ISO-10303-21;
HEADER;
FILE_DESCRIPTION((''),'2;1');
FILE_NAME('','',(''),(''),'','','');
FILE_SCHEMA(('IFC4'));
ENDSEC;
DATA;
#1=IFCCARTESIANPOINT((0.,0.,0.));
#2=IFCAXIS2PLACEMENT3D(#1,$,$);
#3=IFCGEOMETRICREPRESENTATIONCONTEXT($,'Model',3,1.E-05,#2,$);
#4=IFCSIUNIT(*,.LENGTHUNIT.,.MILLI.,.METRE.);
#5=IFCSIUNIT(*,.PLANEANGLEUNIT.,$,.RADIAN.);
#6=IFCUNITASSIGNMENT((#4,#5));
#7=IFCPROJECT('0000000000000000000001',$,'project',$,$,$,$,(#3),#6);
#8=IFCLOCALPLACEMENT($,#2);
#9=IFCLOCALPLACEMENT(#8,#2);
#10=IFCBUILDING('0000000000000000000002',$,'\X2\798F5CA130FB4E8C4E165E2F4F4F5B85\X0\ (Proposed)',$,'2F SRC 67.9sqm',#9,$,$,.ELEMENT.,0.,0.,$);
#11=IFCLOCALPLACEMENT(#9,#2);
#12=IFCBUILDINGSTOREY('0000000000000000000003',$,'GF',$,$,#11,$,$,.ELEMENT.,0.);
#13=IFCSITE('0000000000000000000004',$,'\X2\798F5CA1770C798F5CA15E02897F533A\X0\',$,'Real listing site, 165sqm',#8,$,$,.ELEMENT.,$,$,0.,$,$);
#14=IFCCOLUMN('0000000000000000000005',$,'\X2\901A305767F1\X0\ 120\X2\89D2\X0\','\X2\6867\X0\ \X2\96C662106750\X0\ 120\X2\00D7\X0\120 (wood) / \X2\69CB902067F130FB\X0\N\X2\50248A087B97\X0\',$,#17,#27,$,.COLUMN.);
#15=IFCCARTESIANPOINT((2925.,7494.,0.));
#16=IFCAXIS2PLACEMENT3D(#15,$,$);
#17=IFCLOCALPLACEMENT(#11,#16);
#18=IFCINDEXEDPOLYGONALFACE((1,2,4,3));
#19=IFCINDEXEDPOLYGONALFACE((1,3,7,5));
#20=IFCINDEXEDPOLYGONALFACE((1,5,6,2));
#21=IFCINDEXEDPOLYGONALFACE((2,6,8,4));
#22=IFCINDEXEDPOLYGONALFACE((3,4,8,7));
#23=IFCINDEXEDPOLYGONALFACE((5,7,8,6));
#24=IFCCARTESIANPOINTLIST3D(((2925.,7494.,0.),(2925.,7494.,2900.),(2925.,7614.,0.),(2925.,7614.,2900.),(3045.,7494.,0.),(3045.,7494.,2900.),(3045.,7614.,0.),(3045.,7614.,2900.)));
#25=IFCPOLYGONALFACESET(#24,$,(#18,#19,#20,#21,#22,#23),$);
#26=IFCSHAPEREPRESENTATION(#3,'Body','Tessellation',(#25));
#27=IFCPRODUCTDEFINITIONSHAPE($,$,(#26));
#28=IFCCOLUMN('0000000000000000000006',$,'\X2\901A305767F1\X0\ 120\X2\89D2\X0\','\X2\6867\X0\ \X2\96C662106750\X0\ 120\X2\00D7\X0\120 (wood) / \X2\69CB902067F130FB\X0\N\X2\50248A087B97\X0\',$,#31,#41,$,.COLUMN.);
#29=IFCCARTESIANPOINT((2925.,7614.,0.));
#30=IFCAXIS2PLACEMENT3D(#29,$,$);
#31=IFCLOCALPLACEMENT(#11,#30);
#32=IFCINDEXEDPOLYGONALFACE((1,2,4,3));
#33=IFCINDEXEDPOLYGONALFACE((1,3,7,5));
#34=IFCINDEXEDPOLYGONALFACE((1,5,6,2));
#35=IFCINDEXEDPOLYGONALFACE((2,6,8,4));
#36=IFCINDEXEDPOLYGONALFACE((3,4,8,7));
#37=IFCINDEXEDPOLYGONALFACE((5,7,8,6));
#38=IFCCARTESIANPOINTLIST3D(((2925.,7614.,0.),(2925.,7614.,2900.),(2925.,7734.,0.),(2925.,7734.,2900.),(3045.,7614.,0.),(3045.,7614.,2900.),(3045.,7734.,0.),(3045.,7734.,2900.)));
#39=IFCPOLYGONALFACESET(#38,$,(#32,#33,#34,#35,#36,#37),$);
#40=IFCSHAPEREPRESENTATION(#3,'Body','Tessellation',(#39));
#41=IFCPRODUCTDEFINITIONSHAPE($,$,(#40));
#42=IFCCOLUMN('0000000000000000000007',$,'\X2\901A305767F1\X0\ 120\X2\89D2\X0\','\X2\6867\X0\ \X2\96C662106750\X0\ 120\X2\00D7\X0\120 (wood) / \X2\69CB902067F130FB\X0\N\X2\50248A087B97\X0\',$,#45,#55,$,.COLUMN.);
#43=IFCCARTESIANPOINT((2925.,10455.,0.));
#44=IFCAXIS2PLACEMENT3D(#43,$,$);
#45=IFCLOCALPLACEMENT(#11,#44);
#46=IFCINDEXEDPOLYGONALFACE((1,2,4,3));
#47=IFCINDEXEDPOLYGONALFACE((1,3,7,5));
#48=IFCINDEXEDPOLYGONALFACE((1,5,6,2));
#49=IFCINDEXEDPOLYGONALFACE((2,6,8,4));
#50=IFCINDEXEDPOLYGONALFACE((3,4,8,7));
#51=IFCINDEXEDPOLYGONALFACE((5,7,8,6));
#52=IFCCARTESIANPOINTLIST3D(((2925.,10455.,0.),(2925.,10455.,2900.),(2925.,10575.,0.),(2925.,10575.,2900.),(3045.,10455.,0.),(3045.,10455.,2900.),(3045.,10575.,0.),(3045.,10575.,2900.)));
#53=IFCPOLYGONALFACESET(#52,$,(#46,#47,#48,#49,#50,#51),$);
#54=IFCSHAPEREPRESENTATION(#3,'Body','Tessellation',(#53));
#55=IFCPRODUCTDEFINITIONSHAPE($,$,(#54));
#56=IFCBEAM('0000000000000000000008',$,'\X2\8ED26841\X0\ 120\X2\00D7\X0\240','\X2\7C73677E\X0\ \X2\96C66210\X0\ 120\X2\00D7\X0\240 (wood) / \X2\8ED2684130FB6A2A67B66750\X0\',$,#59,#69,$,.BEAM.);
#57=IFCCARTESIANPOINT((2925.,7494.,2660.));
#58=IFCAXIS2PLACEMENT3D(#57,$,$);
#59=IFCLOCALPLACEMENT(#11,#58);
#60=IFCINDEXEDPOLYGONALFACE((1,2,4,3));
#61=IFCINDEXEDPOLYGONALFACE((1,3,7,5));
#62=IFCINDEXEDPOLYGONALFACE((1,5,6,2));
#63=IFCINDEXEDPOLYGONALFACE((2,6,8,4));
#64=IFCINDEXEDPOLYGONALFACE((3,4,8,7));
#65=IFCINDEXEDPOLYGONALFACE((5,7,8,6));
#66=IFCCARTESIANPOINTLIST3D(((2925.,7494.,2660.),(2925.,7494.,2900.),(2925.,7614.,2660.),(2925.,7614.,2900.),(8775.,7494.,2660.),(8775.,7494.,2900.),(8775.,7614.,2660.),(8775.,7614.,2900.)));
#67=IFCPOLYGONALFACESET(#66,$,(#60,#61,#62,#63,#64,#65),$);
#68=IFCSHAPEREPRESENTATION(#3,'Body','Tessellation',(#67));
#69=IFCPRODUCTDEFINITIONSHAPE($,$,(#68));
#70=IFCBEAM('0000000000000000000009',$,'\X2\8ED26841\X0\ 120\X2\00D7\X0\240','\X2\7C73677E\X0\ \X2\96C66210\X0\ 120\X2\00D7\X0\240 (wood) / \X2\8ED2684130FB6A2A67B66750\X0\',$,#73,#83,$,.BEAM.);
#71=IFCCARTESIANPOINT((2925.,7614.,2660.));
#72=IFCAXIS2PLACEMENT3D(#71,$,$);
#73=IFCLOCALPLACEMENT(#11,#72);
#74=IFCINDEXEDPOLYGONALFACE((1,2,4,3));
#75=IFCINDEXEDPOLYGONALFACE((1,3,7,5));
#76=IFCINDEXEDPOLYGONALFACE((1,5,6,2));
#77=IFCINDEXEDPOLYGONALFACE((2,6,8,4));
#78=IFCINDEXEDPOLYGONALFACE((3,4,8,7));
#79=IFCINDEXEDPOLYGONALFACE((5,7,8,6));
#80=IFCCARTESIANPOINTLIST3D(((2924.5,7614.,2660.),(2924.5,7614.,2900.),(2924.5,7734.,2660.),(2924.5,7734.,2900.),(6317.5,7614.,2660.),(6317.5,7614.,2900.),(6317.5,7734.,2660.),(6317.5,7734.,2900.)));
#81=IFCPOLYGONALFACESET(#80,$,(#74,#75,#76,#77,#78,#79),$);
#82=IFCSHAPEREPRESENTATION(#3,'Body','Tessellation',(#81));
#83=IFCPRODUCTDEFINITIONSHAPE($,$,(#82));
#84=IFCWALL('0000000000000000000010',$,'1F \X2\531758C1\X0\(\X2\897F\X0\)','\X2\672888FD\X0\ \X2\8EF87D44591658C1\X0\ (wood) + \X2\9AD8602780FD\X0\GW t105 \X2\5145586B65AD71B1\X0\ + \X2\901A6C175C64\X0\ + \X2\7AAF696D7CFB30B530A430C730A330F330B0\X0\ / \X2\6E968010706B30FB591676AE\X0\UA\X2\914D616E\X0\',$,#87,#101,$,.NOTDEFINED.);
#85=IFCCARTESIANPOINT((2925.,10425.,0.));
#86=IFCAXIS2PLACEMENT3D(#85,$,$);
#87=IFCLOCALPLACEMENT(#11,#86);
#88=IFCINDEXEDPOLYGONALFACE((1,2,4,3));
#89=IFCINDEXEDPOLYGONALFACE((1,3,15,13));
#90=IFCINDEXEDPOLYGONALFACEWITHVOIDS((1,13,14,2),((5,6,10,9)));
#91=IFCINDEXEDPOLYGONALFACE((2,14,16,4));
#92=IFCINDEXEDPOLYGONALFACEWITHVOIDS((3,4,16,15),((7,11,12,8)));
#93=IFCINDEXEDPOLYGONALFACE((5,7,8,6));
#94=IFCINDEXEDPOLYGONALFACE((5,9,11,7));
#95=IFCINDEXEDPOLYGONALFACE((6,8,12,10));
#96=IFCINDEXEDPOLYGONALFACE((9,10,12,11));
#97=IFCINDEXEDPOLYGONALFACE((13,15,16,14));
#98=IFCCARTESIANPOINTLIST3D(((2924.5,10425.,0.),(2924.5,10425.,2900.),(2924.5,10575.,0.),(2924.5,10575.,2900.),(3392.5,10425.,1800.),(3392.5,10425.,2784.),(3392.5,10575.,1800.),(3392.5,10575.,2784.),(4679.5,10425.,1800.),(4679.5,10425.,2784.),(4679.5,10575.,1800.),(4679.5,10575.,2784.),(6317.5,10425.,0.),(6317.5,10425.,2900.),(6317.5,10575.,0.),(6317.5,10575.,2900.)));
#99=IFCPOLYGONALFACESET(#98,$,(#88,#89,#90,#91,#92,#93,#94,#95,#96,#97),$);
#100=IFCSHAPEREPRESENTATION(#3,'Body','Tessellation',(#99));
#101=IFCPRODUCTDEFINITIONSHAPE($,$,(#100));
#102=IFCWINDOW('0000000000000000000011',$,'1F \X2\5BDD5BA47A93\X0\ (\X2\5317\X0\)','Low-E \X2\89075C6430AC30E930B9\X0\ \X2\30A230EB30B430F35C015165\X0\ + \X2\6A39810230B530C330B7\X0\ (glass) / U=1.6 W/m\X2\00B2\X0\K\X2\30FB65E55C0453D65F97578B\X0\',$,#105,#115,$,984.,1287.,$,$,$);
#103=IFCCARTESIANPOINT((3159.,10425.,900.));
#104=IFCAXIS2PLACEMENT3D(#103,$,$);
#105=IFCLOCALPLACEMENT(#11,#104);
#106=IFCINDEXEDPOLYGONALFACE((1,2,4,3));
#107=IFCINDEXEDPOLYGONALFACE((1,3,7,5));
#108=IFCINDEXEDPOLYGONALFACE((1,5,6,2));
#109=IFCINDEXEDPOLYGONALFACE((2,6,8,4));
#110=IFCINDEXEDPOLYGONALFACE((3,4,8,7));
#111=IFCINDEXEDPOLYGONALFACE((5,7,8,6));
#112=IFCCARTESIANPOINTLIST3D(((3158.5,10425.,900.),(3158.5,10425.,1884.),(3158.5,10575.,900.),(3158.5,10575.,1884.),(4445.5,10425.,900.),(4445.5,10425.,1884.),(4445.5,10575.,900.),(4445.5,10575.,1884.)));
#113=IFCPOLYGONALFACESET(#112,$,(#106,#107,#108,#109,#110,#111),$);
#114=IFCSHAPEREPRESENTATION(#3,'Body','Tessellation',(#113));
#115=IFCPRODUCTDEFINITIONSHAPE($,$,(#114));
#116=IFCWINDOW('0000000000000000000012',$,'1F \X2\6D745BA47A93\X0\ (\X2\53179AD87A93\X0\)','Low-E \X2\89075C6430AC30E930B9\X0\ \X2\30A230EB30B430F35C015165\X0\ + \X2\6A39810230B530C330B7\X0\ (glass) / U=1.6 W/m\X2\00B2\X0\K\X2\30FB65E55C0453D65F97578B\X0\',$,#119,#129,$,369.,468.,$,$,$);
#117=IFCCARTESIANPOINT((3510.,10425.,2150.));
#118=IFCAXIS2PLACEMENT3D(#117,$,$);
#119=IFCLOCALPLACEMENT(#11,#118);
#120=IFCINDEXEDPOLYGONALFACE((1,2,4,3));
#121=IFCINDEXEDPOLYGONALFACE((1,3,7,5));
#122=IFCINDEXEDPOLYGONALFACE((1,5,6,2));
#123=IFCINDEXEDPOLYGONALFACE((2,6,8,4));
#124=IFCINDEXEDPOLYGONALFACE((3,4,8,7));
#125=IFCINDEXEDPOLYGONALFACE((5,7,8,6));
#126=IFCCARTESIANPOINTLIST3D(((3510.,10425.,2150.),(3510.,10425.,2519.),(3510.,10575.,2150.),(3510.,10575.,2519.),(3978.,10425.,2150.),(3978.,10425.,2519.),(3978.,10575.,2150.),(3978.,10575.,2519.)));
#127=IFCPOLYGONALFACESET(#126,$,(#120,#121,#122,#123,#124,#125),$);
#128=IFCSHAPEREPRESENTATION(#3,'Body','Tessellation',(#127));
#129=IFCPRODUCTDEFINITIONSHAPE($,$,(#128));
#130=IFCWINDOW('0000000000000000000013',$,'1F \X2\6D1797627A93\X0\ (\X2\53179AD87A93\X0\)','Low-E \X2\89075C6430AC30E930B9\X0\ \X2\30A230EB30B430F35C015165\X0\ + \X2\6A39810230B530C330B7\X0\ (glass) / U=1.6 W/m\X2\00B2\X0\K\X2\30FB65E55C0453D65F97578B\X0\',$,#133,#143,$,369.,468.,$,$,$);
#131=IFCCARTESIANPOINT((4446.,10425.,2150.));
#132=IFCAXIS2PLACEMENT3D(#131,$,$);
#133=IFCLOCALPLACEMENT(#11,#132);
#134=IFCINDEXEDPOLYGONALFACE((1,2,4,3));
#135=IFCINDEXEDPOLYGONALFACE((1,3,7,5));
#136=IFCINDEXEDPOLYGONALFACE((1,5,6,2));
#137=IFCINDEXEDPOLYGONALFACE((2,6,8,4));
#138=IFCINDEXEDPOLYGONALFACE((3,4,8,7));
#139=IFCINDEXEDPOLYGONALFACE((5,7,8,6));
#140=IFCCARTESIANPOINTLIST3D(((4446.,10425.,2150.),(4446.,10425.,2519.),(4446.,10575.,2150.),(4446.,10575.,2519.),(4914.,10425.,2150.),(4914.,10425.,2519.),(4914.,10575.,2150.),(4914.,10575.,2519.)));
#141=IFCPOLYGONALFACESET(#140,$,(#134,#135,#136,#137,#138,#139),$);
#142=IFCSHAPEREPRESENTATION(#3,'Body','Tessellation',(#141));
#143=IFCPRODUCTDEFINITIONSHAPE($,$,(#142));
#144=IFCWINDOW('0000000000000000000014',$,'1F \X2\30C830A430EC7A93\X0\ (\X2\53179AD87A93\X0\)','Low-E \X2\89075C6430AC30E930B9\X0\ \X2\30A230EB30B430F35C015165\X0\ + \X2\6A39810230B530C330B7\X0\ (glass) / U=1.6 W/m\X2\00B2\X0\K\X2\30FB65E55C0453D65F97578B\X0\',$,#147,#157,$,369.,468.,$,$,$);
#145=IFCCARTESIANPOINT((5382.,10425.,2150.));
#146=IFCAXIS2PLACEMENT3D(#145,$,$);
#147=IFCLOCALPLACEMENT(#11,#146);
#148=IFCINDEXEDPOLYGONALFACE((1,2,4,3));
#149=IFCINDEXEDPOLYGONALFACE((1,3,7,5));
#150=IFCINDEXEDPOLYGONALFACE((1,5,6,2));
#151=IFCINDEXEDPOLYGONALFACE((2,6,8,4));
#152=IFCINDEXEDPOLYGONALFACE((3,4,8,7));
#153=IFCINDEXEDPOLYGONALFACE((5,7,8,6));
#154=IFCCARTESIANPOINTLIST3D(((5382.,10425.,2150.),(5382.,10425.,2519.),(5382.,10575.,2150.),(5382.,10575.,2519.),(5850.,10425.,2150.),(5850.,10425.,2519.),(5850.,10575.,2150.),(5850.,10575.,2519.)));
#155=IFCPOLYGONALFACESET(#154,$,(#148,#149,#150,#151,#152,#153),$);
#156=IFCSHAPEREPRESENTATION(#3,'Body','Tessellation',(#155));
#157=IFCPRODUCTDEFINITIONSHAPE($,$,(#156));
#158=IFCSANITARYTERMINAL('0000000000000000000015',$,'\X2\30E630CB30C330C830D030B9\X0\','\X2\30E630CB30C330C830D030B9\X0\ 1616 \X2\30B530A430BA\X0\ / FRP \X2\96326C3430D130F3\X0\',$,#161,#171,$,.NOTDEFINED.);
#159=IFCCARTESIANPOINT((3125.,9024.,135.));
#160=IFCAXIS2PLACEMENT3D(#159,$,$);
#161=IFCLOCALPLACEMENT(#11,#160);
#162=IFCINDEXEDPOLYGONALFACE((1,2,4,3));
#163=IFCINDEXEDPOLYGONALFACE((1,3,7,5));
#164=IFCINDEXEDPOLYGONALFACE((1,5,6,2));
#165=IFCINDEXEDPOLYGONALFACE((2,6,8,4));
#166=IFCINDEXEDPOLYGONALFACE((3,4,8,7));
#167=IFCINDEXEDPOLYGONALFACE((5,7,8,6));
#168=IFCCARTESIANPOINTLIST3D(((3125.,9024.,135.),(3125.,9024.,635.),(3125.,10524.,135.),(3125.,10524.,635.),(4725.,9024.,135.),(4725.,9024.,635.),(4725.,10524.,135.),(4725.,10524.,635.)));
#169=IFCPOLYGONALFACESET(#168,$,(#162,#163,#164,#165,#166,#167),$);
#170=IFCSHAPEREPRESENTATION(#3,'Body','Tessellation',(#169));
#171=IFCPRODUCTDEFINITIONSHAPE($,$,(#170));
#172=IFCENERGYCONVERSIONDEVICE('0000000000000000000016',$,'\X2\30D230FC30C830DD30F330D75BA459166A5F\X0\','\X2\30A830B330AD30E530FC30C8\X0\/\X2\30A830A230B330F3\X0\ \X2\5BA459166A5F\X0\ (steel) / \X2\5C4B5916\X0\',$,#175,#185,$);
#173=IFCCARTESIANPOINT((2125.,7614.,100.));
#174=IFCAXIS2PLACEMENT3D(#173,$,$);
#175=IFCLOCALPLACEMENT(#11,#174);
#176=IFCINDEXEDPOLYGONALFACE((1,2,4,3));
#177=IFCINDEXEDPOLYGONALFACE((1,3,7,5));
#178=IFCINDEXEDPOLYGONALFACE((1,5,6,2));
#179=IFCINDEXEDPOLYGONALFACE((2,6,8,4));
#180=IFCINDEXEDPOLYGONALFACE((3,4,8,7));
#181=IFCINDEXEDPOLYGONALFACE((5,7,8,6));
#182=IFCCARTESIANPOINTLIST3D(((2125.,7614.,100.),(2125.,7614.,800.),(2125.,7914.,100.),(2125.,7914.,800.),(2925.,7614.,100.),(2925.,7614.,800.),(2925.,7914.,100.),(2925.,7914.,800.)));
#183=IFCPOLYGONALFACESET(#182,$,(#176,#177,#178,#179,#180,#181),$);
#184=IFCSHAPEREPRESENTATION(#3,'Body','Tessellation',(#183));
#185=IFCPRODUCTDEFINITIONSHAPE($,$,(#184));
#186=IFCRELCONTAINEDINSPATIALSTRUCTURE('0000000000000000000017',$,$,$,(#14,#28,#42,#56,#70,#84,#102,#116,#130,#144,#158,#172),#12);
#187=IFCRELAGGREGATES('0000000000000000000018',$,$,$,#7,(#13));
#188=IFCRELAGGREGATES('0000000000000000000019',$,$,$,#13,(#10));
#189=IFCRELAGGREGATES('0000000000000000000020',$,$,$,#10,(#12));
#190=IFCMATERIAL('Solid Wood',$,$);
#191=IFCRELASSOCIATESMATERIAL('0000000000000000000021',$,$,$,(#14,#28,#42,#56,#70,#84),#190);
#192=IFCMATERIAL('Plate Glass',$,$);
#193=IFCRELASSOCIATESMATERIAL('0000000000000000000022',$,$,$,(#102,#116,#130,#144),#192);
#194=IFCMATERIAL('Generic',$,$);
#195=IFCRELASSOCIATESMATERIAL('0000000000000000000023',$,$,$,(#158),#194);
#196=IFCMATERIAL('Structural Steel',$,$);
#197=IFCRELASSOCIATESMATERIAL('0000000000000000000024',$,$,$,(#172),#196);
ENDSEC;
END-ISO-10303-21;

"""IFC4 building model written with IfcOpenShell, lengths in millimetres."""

from ifc_helpers import new_model, si_unit, frame, frame_2d, origin, place, context, project, spatial, rectangle, extrude, material, element, fill, save


model = new_model("IFC4")

# Units and contexts
model_context = context("Model", 3, precision=1e-05, world=origin())
ifc_project = project(units=[si_unit("LENGTHUNIT", "METRE", prefix="MILLI"), si_unit("PLANEANGLEUNIT", "RADIAN")], contexts=[model_context])

# Site, building, storey
site_placement = place(None, origin())
site = spatial("IfcSite", under=ifc_project, at=site_placement, Name="福岡県福岡市西区", ObjectType="Real listing site, 165sqm", CompositionType="ELEMENT", RefElevation=0.0)
building_placement = place(site_placement, origin())
building = spatial("IfcBuilding", under=site, at=building_placement, Name="福岡・二世帯住宅 (Proposed)", ObjectType="2F SRC 67.9sqm", CompositionType="ELEMENT", ElevationOfRefHeight=0.0, ElevationOfTerrain=0.0)
storey_placement = place(building_placement, origin())
storey = spatial("IfcBuildingStorey", under=building, at=storey_placement, Name="GF", CompositionType="ELEMENT", Elevation=0.0)

# Columns
ifc_material_1 = material(Name="Solid Wood")
column_1_placement = place(storey_placement, frame((2925.0, 7494.0, 0.0)))
element("IfcColumn", 1, at=column_1_placement, inside=storey, material=ifc_material_1, Name="通し柱 120角", Description="桧 集成材 120×120 (wood) / 構造柱・N値計算", PredefinedType="COLUMN", context=model_context, shape_type="SweptSolid", body=[
    extrude(rectangle(XDim=120.0, YDim=120.0, at=frame_2d((60.0, 60.0))), frame((2925.0, 7494.0, 0.0)), (0.0, 0.0, 1.0), 2900.0),
])
column_2_placement = place(storey_placement, frame((2925.0, 7614.0, 0.0)))
element("IfcColumn", 2, at=column_2_placement, inside=storey, material=ifc_material_1, Name="通し柱 120角", Description="桧 集成材 120×120 (wood) / 構造柱・N値計算", PredefinedType="COLUMN", context=model_context, shape_type="SweptSolid", body=[
    extrude(rectangle(XDim=120.0, YDim=120.0, at=frame_2d((60.0, 60.0))), frame((2925.0, 7614.0, 0.0)), (0.0, 0.0, 1.0), 2900.0),
])
column_3_placement = place(storey_placement, frame((2925.0, 10455.0, 0.0)))
element("IfcColumn", 3, at=column_3_placement, inside=storey, material=ifc_material_1, Name="通し柱 120角", Description="桧 集成材 120×120 (wood) / 構造柱・N値計算", PredefinedType="COLUMN", context=model_context, shape_type="SweptSolid", body=[
    extrude(rectangle(XDim=120.0, YDim=120.0, at=frame_2d((60.0, 60.0))), frame((2925.0, 10455.0, 0.0)), (0.0, 0.0, 1.0), 2900.0),
])

# Beams
beam_1_placement = place(storey_placement, frame((2925.0, 7494.0, 2660.0)))
element("IfcBeam", 4, at=beam_1_placement, inside=storey, material=ifc_material_1, Name="軒桁 120×240", Description="米松 集成 120×240 (wood) / 軒桁・横架材", PredefinedType="BEAM", context=model_context, shape_type="SweptSolid", body=[
    extrude(rectangle(XDim=5850.0, YDim=120.0, at=frame_2d((2925.0, 60.0))), frame((2925.0, 7494.0, 2660.0)), (0.0, 0.0, 1.0), 240.0),
])
beam_2_placement = place(storey_placement, frame((2925.0, 7614.0, 2660.0)))
element("IfcBeam", 5, at=beam_2_placement, inside=storey, material=ifc_material_1, Name="軒桁 120×240", Description="米松 集成 120×240 (wood) / 軒桁・横架材", PredefinedType="BEAM", context=model_context, shape_type="SweptSolid", body=[
    extrude(rectangle(XDim=3393.0, YDim=120.0, at=frame_2d((1696.0, 60.0))), frame((2925.0, 7614.0, 2660.0)), (0.0, 0.0, 1.0), 240.0),
])

# Wall, openings, windows
wall_1_placement = place(storey_placement, frame((2925.0, 10425.0, 0.0)))
wall_1 = element("IfcWall", 6, at=wall_1_placement, inside=storey, material=ifc_material_1, Name="1F 北壁(西)", Description="木製 軸組外壁 (wood) + 高性能GW t105 充填断熱 + 通気層 + 窯業系サイディング / 準耐火・外皮UA配慮", PredefinedType="NOTDEFINED", context=model_context, shape_type="SweptSolid", body=[
    extrude(rectangle(XDim=3393.0, YDim=150.0, at=frame_2d((1696.0, 75.0))), frame((2925.0, 10425.0, 0.0)), (0.0, 0.0, 1.0), 2900.0),
])
opening_1_placement = place(storey_placement, frame((3159.0, 10425.0, 900.0)))
opening_1 = element("IfcOpeningElement", 7, at=opening_1_placement, cuts=wall_1, PredefinedType="NOTDEFINED", context=model_context, shape_type="SweptSolid", body=[
    extrude(rectangle(XDim=1287.0, YDim=150.0, at=frame_2d((643.0, 75.0))), frame((3159.0, 10425.0, 900.0)), (0.0, 0.0, 1.0), 984.0),
])
opening_2_placement = place(storey_placement, frame((3510.0, 10425.0, 2150.0)))
opening_2 = element("IfcOpeningElement", 8, at=opening_2_placement, cuts=wall_1, PredefinedType="NOTDEFINED", context=model_context, shape_type="SweptSolid", body=[
    extrude(rectangle(XDim=468.0, YDim=150.0, at=frame_2d((234.0, 75.0))), frame((3510.0, 10425.0, 2150.0)), (0.0, 0.0, 1.0), 369.0),
])
opening_3_placement = place(storey_placement, frame((4446.0, 10425.0, 2150.0)))
opening_3 = element("IfcOpeningElement", 9, at=opening_3_placement, cuts=wall_1, PredefinedType="NOTDEFINED", context=model_context, shape_type="SweptSolid", body=[
    extrude(rectangle(XDim=468.0, YDim=150.0, at=frame_2d((234.0, 75.0))), frame((4446.0, 10425.0, 2150.0)), (0.0, 0.0, 1.0), 369.0),
])
opening_4_placement = place(storey_placement, frame((5382.0, 10425.0, 2150.0)))
opening_4 = element("IfcOpeningElement", 10, at=opening_4_placement, cuts=wall_1, PredefinedType="NOTDEFINED", context=model_context, shape_type="SweptSolid", body=[
    extrude(rectangle(XDim=468.0, YDim=150.0, at=frame_2d((234.0, 75.0))), frame((5382.0, 10425.0, 2150.0)), (0.0, 0.0, 1.0), 369.0),
])
ifc_material_2 = material(Name="Plate Glass")
window_1_placement = place(storey_placement, frame((3159.0, 10425.0, 900.0)))
window_1 = element("IfcWindow", 11, at=window_1_placement, inside=storey, material=ifc_material_2, Name="1F 寝室窓 (北)", Description="Low-E 複層ガラス アルゴン封入 + 樹脂サッシ (glass) / U=1.6 W/m²K・日射取得型", OverallHeight=984.0, OverallWidth=1287.0, context=model_context, shape_type="SweptSolid", body=[
    extrude(rectangle(XDim=1287.0, YDim=150.0, at=frame_2d((643.0, 75.0))), frame((3159.0, 10425.0, 900.0)), (0.0, 0.0, 1.0), 984.0),
])
fill(opening_1, window_1)
window_2_placement = place(storey_placement, frame((3510.0, 10425.0, 2150.0)))
window_2 = element("IfcWindow", 12, at=window_2_placement, inside=storey, material=ifc_material_2, Name="1F 浴室窓 (北高窓)", Description="Low-E 複層ガラス アルゴン封入 + 樹脂サッシ (glass) / U=1.6 W/m²K・日射取得型", OverallHeight=369.0, OverallWidth=468.0, context=model_context, shape_type="SweptSolid", body=[
    extrude(rectangle(XDim=468.0, YDim=150.0, at=frame_2d((234.0, 75.0))), frame((3510.0, 10425.0, 2150.0)), (0.0, 0.0, 1.0), 369.0),
])
fill(opening_2, window_2)
window_3_placement = place(storey_placement, frame((4446.0, 10425.0, 2150.0)))
window_3 = element("IfcWindow", 13, at=window_3_placement, inside=storey, material=ifc_material_2, Name="1F 洗面窓 (北高窓)", Description="Low-E 複層ガラス アルゴン封入 + 樹脂サッシ (glass) / U=1.6 W/m²K・日射取得型", OverallHeight=369.0, OverallWidth=468.0, context=model_context, shape_type="SweptSolid", body=[
    extrude(rectangle(XDim=468.0, YDim=150.0, at=frame_2d((234.0, 75.0))), frame((4446.0, 10425.0, 2150.0)), (0.0, 0.0, 1.0), 369.0),
])
fill(opening_3, window_3)
window_4_placement = place(storey_placement, frame((5382.0, 10425.0, 2150.0)))
window_4 = element("IfcWindow", 14, at=window_4_placement, inside=storey, material=ifc_material_2, Name="1F トイレ窓 (北高窓)", Description="Low-E 複層ガラス アルゴン封入 + 樹脂サッシ (glass) / U=1.6 W/m²K・日射取得型", OverallHeight=369.0, OverallWidth=468.0, context=model_context, shape_type="SweptSolid", body=[
    extrude(rectangle(XDim=468.0, YDim=150.0, at=frame_2d((234.0, 75.0))), frame((5382.0, 10425.0, 2150.0)), (0.0, 0.0, 1.0), 369.0),
])
fill(opening_4, window_4)

# Shared definitions
ifc_material_3 = material(Name="Generic")

# Sanitary terminal
sanitary_terminal_placement = place(storey_placement, frame((3125.0, 9024.0, 135.0)))
element("IfcSanitaryTerminal", 15, at=sanitary_terminal_placement, inside=storey, material=ifc_material_3, Name="ユニットバス", Description="ユニットバス 1616 サイズ / FRP 防水パン", PredefinedType="NOTDEFINED", context=model_context, shape_type="SweptSolid", body=[
    extrude(rectangle(XDim=1600.0, YDim=1500.0, at=frame_2d((800.0, 750.0))), frame((3125.0, 9024.0, 135.0)), (0.0, 0.0, 1.0), 500.0),
])

# Energy conversion device
ifc_material_4 = material(Name="Structural Steel")
energy_conversion_device_placement = place(storey_placement, frame((2125.0, 7614.0, 100.0)))
element("IfcEnergyConversionDevice", 16, at=energy_conversion_device_placement, inside=storey, material=ifc_material_4, Name="ヒートポンプ室外機", Description="エコキュート/エアコン 室外機 (steel) / 屋外", context=model_context, shape_type="SweptSolid", body=[
    extrude(rectangle(XDim=800.0, YDim=300.0, at=frame_2d((400.0, 150.0))), frame((2125.0, 7614.0, 100.0)), (0.0, 0.0, 1.0), 700.0),
])

save(model, "model.ifc")
